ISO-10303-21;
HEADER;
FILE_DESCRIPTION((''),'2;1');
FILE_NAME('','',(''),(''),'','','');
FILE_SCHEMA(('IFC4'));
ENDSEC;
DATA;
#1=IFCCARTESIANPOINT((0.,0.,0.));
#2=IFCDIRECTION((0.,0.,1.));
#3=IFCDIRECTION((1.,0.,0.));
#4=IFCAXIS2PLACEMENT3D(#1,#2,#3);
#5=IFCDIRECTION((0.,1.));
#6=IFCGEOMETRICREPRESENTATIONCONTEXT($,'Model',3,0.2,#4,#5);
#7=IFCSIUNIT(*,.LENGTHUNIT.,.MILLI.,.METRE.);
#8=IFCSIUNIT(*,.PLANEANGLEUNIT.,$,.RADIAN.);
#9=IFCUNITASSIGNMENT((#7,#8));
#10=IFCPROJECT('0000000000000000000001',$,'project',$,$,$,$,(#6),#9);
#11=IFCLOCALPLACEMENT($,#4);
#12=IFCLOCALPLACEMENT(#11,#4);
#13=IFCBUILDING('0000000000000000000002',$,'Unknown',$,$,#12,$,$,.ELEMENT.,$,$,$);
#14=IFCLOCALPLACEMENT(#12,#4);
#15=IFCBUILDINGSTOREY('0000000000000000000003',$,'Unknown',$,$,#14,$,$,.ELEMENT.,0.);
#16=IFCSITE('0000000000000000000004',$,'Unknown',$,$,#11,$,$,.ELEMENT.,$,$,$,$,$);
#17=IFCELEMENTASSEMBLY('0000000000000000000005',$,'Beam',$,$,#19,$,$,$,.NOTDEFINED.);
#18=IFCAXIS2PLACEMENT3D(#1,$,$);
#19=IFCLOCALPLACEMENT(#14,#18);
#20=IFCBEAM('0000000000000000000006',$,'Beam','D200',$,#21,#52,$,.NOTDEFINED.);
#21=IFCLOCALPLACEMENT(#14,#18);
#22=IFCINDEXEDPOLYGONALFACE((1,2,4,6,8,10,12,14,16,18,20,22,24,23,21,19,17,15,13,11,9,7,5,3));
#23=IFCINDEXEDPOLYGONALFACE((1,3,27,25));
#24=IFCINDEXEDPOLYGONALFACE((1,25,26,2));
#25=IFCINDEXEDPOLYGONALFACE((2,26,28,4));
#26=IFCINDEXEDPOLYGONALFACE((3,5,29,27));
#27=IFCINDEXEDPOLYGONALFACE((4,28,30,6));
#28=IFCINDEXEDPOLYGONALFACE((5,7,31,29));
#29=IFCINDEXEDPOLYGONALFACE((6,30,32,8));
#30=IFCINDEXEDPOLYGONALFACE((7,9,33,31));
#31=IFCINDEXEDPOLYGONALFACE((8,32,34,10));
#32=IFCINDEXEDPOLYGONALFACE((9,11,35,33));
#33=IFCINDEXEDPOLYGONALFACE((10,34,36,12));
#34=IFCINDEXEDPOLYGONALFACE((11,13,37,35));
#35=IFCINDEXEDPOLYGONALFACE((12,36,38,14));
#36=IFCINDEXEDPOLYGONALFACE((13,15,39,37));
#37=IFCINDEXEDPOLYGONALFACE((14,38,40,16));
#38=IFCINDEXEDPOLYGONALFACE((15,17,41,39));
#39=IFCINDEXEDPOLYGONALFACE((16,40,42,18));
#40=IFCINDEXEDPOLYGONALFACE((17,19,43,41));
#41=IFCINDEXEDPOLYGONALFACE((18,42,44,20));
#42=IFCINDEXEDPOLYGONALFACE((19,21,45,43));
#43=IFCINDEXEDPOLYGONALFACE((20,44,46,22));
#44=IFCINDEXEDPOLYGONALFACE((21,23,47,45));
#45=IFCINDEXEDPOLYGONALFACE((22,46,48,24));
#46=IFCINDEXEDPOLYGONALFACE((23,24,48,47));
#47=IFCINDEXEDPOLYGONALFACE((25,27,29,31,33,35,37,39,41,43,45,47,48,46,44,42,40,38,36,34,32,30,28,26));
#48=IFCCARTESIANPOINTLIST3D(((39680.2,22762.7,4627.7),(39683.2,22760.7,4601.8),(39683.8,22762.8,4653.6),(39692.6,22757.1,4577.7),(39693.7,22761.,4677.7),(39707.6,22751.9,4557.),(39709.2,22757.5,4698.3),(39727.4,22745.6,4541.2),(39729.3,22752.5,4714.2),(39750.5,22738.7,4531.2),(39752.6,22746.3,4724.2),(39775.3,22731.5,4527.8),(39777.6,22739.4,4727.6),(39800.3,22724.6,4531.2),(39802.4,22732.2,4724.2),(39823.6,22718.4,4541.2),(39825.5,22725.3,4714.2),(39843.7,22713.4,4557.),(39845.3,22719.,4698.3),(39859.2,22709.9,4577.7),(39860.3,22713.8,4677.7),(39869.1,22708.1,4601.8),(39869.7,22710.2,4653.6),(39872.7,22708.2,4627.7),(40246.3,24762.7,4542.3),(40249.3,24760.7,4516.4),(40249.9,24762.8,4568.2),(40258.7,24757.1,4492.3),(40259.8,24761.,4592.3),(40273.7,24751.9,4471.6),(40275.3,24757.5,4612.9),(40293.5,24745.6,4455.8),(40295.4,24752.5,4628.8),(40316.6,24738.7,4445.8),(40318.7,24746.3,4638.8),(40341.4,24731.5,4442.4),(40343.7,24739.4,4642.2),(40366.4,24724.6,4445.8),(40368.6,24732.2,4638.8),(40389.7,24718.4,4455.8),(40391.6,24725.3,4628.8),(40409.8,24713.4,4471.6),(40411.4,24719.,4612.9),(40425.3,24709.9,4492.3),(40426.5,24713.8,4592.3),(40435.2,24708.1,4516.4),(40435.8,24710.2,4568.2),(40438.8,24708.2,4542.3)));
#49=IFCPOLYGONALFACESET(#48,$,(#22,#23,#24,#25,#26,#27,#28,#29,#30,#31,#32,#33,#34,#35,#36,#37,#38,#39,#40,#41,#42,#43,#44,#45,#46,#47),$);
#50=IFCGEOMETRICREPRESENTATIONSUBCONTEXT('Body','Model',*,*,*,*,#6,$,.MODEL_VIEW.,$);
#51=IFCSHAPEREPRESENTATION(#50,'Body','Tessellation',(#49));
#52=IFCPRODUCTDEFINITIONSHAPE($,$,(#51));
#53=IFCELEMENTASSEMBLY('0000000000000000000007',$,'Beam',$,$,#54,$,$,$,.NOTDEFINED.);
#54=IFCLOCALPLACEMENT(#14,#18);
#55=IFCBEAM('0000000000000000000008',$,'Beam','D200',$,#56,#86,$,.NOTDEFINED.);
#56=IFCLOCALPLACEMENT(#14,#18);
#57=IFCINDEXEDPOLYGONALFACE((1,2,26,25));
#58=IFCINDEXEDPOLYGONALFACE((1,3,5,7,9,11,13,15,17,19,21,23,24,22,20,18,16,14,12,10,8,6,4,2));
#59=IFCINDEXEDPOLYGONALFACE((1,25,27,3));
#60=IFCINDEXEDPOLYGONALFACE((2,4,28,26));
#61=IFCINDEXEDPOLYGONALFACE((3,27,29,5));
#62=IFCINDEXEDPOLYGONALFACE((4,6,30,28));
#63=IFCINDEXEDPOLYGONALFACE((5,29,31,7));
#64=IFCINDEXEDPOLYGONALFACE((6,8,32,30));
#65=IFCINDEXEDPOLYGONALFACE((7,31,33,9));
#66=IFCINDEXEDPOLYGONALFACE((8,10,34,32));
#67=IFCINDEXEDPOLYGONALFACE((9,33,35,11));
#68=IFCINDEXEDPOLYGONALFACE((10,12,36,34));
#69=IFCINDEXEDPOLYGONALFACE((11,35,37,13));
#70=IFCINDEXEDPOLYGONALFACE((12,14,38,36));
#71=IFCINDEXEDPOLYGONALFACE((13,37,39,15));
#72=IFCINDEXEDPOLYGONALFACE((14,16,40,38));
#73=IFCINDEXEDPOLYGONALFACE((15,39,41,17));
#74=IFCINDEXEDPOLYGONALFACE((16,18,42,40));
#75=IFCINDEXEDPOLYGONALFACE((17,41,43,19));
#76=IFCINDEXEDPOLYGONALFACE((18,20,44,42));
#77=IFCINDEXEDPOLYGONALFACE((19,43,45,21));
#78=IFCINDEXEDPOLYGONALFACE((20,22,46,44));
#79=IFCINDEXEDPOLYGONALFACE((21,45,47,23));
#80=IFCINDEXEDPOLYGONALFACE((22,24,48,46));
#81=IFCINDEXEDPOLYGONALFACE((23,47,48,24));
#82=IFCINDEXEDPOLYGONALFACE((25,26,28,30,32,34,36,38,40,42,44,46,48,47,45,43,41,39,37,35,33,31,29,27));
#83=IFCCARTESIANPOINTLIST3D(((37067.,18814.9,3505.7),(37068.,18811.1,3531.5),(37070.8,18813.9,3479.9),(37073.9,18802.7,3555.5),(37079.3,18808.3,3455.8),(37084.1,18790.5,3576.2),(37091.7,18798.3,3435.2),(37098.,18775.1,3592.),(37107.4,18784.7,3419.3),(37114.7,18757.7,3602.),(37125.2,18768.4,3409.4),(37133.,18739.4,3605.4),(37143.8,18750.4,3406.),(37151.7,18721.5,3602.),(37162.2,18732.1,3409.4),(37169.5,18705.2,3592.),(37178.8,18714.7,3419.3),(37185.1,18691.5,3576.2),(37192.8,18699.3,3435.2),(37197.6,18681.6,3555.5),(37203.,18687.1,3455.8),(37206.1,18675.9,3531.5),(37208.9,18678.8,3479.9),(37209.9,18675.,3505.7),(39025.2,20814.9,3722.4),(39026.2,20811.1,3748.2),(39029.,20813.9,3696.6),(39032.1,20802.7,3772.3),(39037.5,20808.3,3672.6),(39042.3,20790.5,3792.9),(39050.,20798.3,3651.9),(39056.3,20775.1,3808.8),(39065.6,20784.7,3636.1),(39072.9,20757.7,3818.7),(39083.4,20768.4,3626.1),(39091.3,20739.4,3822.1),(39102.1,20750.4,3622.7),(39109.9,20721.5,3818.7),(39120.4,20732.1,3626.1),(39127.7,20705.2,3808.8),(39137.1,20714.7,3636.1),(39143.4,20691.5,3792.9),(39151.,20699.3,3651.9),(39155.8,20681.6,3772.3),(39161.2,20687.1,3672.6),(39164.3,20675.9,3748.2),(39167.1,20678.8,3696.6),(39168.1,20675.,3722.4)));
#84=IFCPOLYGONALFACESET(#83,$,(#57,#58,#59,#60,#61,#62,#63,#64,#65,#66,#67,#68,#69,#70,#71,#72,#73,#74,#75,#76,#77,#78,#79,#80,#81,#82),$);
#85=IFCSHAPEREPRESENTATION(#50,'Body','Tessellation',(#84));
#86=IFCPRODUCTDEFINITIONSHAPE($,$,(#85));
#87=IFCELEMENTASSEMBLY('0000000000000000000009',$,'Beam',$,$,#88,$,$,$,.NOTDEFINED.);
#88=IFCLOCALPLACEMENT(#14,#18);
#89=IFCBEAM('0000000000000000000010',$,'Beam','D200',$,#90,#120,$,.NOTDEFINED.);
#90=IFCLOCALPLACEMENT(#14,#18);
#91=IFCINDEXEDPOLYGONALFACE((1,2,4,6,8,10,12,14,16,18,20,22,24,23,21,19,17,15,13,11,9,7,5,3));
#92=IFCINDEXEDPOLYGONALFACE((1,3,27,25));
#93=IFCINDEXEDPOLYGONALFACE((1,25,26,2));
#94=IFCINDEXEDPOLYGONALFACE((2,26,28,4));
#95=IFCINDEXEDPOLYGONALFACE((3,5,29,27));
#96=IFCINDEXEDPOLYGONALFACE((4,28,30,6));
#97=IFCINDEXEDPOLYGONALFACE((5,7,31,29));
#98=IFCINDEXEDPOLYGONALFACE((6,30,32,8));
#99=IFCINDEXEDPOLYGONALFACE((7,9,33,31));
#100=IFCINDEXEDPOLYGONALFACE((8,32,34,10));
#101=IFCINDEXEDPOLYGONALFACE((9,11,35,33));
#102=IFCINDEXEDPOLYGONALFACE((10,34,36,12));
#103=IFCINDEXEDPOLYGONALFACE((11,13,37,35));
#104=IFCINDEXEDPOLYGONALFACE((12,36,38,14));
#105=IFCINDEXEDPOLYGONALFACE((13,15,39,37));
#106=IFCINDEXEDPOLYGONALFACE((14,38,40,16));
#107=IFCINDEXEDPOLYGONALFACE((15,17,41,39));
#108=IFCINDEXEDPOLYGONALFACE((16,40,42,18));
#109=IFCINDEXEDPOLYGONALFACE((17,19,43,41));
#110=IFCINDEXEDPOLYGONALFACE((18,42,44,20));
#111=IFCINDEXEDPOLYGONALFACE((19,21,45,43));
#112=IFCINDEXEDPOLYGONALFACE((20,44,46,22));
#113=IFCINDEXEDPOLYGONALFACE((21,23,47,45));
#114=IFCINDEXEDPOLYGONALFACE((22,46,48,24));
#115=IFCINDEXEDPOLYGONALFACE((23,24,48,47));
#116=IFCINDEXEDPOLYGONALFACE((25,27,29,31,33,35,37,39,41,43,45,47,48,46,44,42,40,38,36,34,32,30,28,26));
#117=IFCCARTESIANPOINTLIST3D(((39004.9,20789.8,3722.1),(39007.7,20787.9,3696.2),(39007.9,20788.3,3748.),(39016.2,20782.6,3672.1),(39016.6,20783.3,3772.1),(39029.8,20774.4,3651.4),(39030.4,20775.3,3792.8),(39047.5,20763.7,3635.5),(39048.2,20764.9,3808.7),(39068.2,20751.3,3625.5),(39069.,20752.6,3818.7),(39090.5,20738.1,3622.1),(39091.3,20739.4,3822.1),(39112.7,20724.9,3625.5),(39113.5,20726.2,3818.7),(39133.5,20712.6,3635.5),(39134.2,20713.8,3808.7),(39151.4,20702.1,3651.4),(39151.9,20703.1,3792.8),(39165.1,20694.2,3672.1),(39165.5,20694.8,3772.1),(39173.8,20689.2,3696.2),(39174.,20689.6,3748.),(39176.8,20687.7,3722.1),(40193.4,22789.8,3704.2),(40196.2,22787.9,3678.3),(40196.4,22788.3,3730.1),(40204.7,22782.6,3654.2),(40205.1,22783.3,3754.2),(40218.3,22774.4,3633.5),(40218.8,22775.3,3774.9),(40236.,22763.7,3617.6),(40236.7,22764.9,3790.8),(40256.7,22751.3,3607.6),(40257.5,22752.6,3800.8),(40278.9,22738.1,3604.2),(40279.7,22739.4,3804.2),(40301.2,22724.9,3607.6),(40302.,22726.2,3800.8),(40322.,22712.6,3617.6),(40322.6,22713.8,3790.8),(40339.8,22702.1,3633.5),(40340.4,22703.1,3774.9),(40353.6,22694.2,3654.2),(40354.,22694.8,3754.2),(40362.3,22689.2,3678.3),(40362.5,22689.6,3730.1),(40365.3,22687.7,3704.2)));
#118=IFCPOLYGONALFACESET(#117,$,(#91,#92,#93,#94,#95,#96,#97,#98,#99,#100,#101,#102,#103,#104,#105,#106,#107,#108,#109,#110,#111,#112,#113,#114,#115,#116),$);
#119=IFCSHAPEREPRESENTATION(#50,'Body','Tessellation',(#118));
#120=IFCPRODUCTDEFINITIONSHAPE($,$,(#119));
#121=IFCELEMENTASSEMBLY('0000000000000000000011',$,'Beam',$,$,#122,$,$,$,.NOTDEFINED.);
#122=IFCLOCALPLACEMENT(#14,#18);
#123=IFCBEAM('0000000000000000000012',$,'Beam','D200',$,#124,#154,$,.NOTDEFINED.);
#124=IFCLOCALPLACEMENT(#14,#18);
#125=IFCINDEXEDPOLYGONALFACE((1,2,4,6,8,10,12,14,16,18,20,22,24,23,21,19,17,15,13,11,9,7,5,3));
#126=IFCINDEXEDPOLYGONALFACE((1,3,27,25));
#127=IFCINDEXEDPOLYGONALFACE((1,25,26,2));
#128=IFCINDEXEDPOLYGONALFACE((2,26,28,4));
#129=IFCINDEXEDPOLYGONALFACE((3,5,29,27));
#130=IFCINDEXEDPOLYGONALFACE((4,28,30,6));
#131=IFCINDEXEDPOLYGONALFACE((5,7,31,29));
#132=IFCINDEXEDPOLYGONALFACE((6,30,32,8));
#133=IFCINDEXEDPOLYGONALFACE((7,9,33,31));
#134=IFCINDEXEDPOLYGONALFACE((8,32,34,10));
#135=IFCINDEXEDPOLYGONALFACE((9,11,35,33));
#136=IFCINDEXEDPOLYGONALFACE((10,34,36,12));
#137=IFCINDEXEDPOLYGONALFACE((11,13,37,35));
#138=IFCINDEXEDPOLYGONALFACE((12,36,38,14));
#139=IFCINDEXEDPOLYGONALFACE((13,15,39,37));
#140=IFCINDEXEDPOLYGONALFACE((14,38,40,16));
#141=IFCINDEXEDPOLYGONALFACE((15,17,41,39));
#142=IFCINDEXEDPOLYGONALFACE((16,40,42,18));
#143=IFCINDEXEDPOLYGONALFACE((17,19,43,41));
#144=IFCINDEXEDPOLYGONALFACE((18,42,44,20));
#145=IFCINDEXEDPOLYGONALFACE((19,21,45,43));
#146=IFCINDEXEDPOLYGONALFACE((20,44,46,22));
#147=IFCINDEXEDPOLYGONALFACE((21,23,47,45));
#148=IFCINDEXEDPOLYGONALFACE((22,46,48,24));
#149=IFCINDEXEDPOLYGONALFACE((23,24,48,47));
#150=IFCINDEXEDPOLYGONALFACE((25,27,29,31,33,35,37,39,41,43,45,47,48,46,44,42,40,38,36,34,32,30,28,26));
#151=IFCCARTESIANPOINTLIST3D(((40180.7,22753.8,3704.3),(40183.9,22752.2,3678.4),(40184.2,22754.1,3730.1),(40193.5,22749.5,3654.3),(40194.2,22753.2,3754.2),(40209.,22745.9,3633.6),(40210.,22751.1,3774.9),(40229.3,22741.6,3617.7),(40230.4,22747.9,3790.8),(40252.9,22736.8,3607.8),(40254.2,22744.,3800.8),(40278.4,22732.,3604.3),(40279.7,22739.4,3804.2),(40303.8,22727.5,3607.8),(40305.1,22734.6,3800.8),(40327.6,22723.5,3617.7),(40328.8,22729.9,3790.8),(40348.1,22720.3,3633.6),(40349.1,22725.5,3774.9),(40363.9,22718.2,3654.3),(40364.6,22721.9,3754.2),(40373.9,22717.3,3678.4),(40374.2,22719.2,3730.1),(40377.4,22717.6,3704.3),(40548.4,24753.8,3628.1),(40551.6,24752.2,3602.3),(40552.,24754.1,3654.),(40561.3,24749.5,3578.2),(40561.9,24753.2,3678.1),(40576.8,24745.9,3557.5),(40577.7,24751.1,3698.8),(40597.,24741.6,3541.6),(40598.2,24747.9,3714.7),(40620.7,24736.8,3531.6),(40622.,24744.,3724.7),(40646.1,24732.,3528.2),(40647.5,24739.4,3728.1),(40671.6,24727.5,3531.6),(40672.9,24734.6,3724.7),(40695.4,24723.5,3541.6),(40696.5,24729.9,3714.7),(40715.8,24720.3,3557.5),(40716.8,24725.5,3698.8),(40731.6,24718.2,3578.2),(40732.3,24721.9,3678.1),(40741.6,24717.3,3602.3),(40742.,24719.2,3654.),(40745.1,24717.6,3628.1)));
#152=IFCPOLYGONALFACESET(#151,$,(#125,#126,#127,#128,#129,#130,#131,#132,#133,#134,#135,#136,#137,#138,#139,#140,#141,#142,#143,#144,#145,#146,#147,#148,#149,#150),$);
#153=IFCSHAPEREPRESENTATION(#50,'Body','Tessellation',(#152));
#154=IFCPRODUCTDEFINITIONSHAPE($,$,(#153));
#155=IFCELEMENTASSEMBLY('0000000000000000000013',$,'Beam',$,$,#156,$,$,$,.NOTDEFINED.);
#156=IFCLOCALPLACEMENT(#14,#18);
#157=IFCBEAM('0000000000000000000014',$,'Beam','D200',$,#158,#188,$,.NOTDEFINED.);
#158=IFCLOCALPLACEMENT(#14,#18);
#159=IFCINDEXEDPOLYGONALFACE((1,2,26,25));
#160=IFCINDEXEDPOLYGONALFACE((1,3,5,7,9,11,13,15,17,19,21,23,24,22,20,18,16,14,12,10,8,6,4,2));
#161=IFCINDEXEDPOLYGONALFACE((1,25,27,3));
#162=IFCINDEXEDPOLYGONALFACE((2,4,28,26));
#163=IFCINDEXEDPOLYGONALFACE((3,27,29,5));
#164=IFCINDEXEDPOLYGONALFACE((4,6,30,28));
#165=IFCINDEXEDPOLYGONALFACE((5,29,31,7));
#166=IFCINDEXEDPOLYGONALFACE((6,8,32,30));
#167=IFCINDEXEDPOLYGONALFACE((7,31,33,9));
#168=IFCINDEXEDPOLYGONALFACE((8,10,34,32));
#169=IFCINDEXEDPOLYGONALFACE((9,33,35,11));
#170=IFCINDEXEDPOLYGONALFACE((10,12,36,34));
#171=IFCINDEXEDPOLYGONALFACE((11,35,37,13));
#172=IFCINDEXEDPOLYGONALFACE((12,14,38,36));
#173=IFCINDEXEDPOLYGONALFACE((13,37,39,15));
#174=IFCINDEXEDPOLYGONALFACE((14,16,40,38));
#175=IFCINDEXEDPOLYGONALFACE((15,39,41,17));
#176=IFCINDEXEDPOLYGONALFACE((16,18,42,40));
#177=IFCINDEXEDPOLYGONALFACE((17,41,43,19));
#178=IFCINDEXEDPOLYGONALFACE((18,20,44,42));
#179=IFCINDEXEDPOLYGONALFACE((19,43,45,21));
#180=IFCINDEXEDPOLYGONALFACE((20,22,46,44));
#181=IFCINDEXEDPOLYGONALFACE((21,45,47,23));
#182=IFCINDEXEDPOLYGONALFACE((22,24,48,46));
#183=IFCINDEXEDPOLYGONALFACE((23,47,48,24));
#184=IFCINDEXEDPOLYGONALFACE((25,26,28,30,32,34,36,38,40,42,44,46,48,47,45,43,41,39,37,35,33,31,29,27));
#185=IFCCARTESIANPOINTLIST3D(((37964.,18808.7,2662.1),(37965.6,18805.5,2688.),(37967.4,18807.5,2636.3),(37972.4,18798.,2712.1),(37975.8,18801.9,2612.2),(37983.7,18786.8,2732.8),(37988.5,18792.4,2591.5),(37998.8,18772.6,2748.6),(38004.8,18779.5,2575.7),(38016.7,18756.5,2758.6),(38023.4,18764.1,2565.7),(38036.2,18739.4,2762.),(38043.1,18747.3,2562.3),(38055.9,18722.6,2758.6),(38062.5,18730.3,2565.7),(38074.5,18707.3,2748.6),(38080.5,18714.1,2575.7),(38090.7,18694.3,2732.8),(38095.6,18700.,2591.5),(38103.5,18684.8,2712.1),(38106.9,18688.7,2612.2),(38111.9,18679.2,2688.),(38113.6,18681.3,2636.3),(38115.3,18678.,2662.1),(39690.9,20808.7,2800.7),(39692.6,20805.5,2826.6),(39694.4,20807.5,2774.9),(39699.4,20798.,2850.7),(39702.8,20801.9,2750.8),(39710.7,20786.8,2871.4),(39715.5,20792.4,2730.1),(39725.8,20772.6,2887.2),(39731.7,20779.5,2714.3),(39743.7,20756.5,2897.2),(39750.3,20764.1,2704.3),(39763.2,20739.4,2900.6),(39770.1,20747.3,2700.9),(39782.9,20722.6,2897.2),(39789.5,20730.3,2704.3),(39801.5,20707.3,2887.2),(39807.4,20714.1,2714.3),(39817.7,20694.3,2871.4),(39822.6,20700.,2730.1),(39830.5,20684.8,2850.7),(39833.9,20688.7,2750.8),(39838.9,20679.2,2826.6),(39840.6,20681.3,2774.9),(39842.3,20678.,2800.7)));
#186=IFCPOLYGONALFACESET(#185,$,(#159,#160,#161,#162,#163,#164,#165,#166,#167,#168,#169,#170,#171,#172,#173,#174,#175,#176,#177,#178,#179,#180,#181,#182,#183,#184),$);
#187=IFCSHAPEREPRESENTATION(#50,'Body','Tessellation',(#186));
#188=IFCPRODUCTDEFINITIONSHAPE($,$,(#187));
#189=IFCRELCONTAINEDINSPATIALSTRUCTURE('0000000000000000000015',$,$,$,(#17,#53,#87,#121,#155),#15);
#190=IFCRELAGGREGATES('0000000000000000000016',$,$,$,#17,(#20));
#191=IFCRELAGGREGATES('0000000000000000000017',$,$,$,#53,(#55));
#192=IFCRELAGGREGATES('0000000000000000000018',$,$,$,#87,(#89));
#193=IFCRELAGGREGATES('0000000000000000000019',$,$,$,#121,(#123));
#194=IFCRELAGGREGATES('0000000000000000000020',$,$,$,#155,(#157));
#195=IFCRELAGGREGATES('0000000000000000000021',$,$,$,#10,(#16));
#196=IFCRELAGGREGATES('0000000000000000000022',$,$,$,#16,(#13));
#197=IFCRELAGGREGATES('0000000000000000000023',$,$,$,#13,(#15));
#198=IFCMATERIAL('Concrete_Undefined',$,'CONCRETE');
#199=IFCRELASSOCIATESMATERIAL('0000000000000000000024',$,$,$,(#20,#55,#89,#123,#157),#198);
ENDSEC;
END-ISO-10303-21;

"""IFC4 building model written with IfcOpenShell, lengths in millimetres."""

from ifc_helpers import new_model, si_unit, direction, frame, origin_with_axes, place, context, subcontext, project, spatial, line, indexed_curve, outline, extrude, material, element, aggregate, save


model = new_model("IFC4")

# Units and contexts
model_context = context("Model", 3, precision=0.2, world=origin_with_axes(), true_north=direction((0.0, 1.0)))
body_context = subcontext(model_context, "Body", "Model", "MODEL_VIEW")
ifc_project = project(units=[si_unit("LENGTHUNIT", "METRE", prefix="MILLI"), si_unit("PLANEANGLEUNIT", "RADIAN")], contexts=[model_context])

# Site, building, storey
site_placement = place(None, origin_with_axes())
site = spatial("IfcSite", under=ifc_project, at=site_placement, Name="Unknown", CompositionType="ELEMENT")
building_placement = place(site_placement, origin_with_axes())
building = spatial("IfcBuilding", under=site, at=building_placement, Name="Unknown", CompositionType="ELEMENT")
storey_placement = place(building_placement, origin_with_axes())
storey = spatial("IfcBuildingStorey", under=building, at=storey_placement, Name="Unknown", CompositionType="ELEMENT", Elevation=0.0)

# Element assemblies, beams
ifc_material = material(Name="Concrete_Undefined", Category="CONCRETE")
assembly_1_placement = place(storey_placement, frame((40342.6, 24735.5, 4542.3), z_axis=(-0.962196, 0.272356, 0.0), x_axis=(-0.272127, -0.961385, 0.041052)))
assembly_1 = element("IfcElementAssembly", 1, at=assembly_1_placement, inside=storey, Name="Beam", PredefinedType="NOTDEFINED")
beam_1_placement = place(assembly_1_placement, origin_with_axes())
beam_1 = element("IfcBeam", 2, at=beam_1_placement, material=ifc_material, Name="Beam", Description="D200", PredefinedType="NOTDEFINED", context=body_context, shape_type="SolidModel", body=[
    extrude(outline(indexed_curve([(100.0, 0.0), (96.6, 25.9), (86.6, 50.0), (70.7, 70.7), (50.0, 86.6), (25.9, 96.6), (0.0, 100.0), (-25.9, 96.6), (-50.0, 86.6), (-70.7, 70.7), (-86.6, 50.0), (-96.6, 25.9), (-100.0, 0.0), (-96.6, -25.9), (-86.6, -50.0), (-70.7, -70.7), (-50.0, -86.6), (-25.9, -96.6), (0.0, -100.0), (25.9, -96.6), (50.0, -86.6), (70.7, -70.7), (86.6, -50.0), (96.6, -25.9)], segments=[line(1, 2, 3, 4, 5, 6, 7, 8, 9, 10, 11, 12, 13, 14, 15, 16, 17, 18, 19, 20, 21, 22, 23, 24, 1)])), frame((0.0, 0.0, 0.0), z_axis=(-1.0, 0.0, 0.0), x_axis=(0.0, 0.0, 1.0)), (0.0, 0.0, -1.0), 2080.3),
])
aggregate(assembly_1, [beam_1])
assembly_2_placement = place(storey_placement, frame((39096.7, 20744.9, 3722.4), z_axis=(-0.714532, 0.699603, 0.0), x_axis=(-0.697514, -0.712399, -0.077209)))
assembly_2 = element("IfcElementAssembly", 3, at=assembly_2_placement, inside=storey, Name="Beam", PredefinedType="NOTDEFINED")
beam_2_placement = place(assembly_2_placement, origin_with_axes())
beam_2 = element("IfcBeam", 4, at=beam_2_placement, material=ifc_material, Name="Beam", Description="D200", PredefinedType="NOTDEFINED", context=body_context, shape_type="SolidModel", body=[
    extrude(outline(indexed_curve([(100.0, 0.0), (96.6, 25.9), (86.6, 50.0), (70.7, 70.7), (50.0, 86.6), (25.9, 96.6), (0.0, 100.0), (-25.9, 96.6), (-50.0, 86.6), (-70.7, 70.7), (-86.6, 50.0), (-96.6, 25.9), (-100.0, 0.0), (-96.6, -25.9), (-86.6, -50.0), (-70.7, -70.7), (-50.0, -86.6), (-25.9, -96.6), (0.0, -100.0), (25.9, -96.6), (50.0, -86.6), (70.7, -70.7), (86.6, -50.0), (96.6, -25.9)], segments=[line(1, 2, 3, 4, 5, 6, 7, 8, 9, 10, 11, 12, 13, 14, 15, 16, 17, 18, 19, 20, 21, 22, 23, 24, 1)])), frame((0.0, 0.0, 0.0), z_axis=(-1.0, 0.0, 0.0), x_axis=(0.0, 0.0, 1.0)), (0.0, 0.0, -1.0), 2807.4),
])
aggregate(assembly_2, [beam_2])
assembly_3_placement = place(storey_placement, frame((40279.3, 22738.7, 3704.2), z_axis=(-0.859674, 0.510844, 0.0), x_axis=(-0.510829, -0.859648, 0.007697)))
assembly_3 = element("IfcElementAssembly", 5, at=assembly_3_placement, inside=storey, Name="Beam", PredefinedType="NOTDEFINED")
beam_3_placement = place(assembly_3_placement, origin_with_axes())
beam_3 = element("IfcBeam", 6, at=beam_3_placement, material=ifc_material, Name="Beam", Description="D200", PredefinedType="NOTDEFINED", context=body_context, shape_type="SolidModel", body=[
    extrude(outline(indexed_curve([(100.0, 0.0), (96.6, 25.9), (86.6, 50.0), (70.7, 70.7), (50.0, 86.6), (25.9, 96.6), (0.0, 100.0), (-25.9, 96.6), (-50.0, 86.6), (-70.7, 70.7), (-86.6, 50.0), (-96.6, 25.9), (-100.0, 0.0), (-96.6, -25.9), (-86.6, -50.0), (-70.7, -70.7), (-50.0, -86.6), (-25.9, -96.6), (0.0, -100.0), (25.9, -96.6), (50.0, -86.6), (70.7, -70.7), (86.6, -50.0), (96.6, -25.9)], segments=[line(1, 2, 3, 4, 5, 6, 7, 8, 9, 10, 11, 12, 13, 14, 15, 16, 17, 18, 19, 20, 21, 22, 23, 24, 1)])), frame((0.0, 0.0, 0.0), z_axis=(-1.0, 0.0, 0.0), x_axis=(0.0, 0.0, 1.0)), (0.0, 0.0, -1.0), 2326.5),
])
aggregate(assembly_3, [beam_3])
assembly_4_placement = place(storey_placement, frame((40646.8, 24735.7, 3628.1), z_axis=(-0.983513, 0.180837, 0.0), x_axis=(-0.180711, -0.982824, 0.037419)))
assembly_4 = element("IfcElementAssembly", 7, at=assembly_4_placement, inside=storey, Name="Beam", PredefinedType="NOTDEFINED")
beam_4_placement = place(assembly_4_placement, origin_with_axes())
beam_4 = element("IfcBeam", 8, at=beam_4_placement, material=ifc_material, Name="Beam", Description="D200", PredefinedType="NOTDEFINED", context=body_context, shape_type="SolidModel", body=[
    extrude(outline(indexed_curve([(100.0, 0.0), (96.6, 25.9), (86.6, 50.0), (70.7, 70.7), (50.0, 86.6), (25.9, 96.6), (0.0, 100.0), (-25.9, 96.6), (-50.0, 86.6), (-70.7, 70.7), (-86.6, 50.0), (-96.6, 25.9), (-100.0, 0.0), (-96.6, -25.9), (-86.6, -50.0), (-70.7, -70.7), (-50.0, -86.6), (-25.9, -96.6), (0.0, -100.0), (25.9, -96.6), (50.0, -86.6), (70.7, -70.7), (86.6, -50.0), (96.6, -25.9)], segments=[line(1, 2, 3, 4, 5, 6, 7, 8, 9, 10, 11, 12, 13, 14, 15, 16, 17, 18, 19, 20, 21, 22, 23, 24, 1)])), frame((0.0, 0.0, 0.0), z_axis=(-1.0, 0.0, 0.0), x_axis=(0.0, 0.0, 1.0)), (0.0, 0.0, -1.0), 2035.0),
])
aggregate(assembly_4, [beam_4])
assembly_5_placement = place(storey_placement, frame((39766.6, 20743.4, 2800.7), z_axis=(-0.756877, 0.653557, 0.0), x_axis=(-0.65266, -0.755838, -0.052382)))
assembly_5 = element("IfcElementAssembly", 9, at=assembly_5_placement, inside=storey, Name="Beam", PredefinedType="NOTDEFINED")
beam_5_placement = place(assembly_5_placement, origin_with_axes())
beam_5 = element("IfcBeam", 10, at=beam_5_placement, material=ifc_material, Name="Beam", Description="D200", PredefinedType="NOTDEFINED", context=body_context, shape_type="SolidModel", body=[
    extrude(outline(indexed_curve([(100.0, 0.0), (96.6, 25.9), (86.6, 50.0), (70.7, 70.7), (50.0, 86.6), (25.9, 96.6), (0.0, 100.0), (-25.9, 96.6), (-50.0, 86.6), (-70.7, 70.7), (-86.6, 50.0), (-96.6, 25.9), (-100.0, 0.0), (-96.6, -25.9), (-86.6, -50.0), (-70.7, -70.7), (-50.0, -86.6), (-25.9, -96.6), (0.0, -100.0), (25.9, -96.6), (50.0, -86.6), (70.7, -70.7), (86.6, -50.0), (96.6, -25.9)], segments=[line(1, 2, 3, 4, 5, 6, 7, 8, 9, 10, 11, 12, 13, 14, 15, 16, 17, 18, 19, 20, 21, 22, 23, 24, 1)])), frame((0.0, 0.0, 0.0), z_axis=(-1.0, 0.0, 0.0), x_axis=(0.0, 0.0, 1.0)), (0.0, 0.0, -1.0), 2646.1),
])
aggregate(assembly_5, [beam_5])

save(model, "model.ifc")
